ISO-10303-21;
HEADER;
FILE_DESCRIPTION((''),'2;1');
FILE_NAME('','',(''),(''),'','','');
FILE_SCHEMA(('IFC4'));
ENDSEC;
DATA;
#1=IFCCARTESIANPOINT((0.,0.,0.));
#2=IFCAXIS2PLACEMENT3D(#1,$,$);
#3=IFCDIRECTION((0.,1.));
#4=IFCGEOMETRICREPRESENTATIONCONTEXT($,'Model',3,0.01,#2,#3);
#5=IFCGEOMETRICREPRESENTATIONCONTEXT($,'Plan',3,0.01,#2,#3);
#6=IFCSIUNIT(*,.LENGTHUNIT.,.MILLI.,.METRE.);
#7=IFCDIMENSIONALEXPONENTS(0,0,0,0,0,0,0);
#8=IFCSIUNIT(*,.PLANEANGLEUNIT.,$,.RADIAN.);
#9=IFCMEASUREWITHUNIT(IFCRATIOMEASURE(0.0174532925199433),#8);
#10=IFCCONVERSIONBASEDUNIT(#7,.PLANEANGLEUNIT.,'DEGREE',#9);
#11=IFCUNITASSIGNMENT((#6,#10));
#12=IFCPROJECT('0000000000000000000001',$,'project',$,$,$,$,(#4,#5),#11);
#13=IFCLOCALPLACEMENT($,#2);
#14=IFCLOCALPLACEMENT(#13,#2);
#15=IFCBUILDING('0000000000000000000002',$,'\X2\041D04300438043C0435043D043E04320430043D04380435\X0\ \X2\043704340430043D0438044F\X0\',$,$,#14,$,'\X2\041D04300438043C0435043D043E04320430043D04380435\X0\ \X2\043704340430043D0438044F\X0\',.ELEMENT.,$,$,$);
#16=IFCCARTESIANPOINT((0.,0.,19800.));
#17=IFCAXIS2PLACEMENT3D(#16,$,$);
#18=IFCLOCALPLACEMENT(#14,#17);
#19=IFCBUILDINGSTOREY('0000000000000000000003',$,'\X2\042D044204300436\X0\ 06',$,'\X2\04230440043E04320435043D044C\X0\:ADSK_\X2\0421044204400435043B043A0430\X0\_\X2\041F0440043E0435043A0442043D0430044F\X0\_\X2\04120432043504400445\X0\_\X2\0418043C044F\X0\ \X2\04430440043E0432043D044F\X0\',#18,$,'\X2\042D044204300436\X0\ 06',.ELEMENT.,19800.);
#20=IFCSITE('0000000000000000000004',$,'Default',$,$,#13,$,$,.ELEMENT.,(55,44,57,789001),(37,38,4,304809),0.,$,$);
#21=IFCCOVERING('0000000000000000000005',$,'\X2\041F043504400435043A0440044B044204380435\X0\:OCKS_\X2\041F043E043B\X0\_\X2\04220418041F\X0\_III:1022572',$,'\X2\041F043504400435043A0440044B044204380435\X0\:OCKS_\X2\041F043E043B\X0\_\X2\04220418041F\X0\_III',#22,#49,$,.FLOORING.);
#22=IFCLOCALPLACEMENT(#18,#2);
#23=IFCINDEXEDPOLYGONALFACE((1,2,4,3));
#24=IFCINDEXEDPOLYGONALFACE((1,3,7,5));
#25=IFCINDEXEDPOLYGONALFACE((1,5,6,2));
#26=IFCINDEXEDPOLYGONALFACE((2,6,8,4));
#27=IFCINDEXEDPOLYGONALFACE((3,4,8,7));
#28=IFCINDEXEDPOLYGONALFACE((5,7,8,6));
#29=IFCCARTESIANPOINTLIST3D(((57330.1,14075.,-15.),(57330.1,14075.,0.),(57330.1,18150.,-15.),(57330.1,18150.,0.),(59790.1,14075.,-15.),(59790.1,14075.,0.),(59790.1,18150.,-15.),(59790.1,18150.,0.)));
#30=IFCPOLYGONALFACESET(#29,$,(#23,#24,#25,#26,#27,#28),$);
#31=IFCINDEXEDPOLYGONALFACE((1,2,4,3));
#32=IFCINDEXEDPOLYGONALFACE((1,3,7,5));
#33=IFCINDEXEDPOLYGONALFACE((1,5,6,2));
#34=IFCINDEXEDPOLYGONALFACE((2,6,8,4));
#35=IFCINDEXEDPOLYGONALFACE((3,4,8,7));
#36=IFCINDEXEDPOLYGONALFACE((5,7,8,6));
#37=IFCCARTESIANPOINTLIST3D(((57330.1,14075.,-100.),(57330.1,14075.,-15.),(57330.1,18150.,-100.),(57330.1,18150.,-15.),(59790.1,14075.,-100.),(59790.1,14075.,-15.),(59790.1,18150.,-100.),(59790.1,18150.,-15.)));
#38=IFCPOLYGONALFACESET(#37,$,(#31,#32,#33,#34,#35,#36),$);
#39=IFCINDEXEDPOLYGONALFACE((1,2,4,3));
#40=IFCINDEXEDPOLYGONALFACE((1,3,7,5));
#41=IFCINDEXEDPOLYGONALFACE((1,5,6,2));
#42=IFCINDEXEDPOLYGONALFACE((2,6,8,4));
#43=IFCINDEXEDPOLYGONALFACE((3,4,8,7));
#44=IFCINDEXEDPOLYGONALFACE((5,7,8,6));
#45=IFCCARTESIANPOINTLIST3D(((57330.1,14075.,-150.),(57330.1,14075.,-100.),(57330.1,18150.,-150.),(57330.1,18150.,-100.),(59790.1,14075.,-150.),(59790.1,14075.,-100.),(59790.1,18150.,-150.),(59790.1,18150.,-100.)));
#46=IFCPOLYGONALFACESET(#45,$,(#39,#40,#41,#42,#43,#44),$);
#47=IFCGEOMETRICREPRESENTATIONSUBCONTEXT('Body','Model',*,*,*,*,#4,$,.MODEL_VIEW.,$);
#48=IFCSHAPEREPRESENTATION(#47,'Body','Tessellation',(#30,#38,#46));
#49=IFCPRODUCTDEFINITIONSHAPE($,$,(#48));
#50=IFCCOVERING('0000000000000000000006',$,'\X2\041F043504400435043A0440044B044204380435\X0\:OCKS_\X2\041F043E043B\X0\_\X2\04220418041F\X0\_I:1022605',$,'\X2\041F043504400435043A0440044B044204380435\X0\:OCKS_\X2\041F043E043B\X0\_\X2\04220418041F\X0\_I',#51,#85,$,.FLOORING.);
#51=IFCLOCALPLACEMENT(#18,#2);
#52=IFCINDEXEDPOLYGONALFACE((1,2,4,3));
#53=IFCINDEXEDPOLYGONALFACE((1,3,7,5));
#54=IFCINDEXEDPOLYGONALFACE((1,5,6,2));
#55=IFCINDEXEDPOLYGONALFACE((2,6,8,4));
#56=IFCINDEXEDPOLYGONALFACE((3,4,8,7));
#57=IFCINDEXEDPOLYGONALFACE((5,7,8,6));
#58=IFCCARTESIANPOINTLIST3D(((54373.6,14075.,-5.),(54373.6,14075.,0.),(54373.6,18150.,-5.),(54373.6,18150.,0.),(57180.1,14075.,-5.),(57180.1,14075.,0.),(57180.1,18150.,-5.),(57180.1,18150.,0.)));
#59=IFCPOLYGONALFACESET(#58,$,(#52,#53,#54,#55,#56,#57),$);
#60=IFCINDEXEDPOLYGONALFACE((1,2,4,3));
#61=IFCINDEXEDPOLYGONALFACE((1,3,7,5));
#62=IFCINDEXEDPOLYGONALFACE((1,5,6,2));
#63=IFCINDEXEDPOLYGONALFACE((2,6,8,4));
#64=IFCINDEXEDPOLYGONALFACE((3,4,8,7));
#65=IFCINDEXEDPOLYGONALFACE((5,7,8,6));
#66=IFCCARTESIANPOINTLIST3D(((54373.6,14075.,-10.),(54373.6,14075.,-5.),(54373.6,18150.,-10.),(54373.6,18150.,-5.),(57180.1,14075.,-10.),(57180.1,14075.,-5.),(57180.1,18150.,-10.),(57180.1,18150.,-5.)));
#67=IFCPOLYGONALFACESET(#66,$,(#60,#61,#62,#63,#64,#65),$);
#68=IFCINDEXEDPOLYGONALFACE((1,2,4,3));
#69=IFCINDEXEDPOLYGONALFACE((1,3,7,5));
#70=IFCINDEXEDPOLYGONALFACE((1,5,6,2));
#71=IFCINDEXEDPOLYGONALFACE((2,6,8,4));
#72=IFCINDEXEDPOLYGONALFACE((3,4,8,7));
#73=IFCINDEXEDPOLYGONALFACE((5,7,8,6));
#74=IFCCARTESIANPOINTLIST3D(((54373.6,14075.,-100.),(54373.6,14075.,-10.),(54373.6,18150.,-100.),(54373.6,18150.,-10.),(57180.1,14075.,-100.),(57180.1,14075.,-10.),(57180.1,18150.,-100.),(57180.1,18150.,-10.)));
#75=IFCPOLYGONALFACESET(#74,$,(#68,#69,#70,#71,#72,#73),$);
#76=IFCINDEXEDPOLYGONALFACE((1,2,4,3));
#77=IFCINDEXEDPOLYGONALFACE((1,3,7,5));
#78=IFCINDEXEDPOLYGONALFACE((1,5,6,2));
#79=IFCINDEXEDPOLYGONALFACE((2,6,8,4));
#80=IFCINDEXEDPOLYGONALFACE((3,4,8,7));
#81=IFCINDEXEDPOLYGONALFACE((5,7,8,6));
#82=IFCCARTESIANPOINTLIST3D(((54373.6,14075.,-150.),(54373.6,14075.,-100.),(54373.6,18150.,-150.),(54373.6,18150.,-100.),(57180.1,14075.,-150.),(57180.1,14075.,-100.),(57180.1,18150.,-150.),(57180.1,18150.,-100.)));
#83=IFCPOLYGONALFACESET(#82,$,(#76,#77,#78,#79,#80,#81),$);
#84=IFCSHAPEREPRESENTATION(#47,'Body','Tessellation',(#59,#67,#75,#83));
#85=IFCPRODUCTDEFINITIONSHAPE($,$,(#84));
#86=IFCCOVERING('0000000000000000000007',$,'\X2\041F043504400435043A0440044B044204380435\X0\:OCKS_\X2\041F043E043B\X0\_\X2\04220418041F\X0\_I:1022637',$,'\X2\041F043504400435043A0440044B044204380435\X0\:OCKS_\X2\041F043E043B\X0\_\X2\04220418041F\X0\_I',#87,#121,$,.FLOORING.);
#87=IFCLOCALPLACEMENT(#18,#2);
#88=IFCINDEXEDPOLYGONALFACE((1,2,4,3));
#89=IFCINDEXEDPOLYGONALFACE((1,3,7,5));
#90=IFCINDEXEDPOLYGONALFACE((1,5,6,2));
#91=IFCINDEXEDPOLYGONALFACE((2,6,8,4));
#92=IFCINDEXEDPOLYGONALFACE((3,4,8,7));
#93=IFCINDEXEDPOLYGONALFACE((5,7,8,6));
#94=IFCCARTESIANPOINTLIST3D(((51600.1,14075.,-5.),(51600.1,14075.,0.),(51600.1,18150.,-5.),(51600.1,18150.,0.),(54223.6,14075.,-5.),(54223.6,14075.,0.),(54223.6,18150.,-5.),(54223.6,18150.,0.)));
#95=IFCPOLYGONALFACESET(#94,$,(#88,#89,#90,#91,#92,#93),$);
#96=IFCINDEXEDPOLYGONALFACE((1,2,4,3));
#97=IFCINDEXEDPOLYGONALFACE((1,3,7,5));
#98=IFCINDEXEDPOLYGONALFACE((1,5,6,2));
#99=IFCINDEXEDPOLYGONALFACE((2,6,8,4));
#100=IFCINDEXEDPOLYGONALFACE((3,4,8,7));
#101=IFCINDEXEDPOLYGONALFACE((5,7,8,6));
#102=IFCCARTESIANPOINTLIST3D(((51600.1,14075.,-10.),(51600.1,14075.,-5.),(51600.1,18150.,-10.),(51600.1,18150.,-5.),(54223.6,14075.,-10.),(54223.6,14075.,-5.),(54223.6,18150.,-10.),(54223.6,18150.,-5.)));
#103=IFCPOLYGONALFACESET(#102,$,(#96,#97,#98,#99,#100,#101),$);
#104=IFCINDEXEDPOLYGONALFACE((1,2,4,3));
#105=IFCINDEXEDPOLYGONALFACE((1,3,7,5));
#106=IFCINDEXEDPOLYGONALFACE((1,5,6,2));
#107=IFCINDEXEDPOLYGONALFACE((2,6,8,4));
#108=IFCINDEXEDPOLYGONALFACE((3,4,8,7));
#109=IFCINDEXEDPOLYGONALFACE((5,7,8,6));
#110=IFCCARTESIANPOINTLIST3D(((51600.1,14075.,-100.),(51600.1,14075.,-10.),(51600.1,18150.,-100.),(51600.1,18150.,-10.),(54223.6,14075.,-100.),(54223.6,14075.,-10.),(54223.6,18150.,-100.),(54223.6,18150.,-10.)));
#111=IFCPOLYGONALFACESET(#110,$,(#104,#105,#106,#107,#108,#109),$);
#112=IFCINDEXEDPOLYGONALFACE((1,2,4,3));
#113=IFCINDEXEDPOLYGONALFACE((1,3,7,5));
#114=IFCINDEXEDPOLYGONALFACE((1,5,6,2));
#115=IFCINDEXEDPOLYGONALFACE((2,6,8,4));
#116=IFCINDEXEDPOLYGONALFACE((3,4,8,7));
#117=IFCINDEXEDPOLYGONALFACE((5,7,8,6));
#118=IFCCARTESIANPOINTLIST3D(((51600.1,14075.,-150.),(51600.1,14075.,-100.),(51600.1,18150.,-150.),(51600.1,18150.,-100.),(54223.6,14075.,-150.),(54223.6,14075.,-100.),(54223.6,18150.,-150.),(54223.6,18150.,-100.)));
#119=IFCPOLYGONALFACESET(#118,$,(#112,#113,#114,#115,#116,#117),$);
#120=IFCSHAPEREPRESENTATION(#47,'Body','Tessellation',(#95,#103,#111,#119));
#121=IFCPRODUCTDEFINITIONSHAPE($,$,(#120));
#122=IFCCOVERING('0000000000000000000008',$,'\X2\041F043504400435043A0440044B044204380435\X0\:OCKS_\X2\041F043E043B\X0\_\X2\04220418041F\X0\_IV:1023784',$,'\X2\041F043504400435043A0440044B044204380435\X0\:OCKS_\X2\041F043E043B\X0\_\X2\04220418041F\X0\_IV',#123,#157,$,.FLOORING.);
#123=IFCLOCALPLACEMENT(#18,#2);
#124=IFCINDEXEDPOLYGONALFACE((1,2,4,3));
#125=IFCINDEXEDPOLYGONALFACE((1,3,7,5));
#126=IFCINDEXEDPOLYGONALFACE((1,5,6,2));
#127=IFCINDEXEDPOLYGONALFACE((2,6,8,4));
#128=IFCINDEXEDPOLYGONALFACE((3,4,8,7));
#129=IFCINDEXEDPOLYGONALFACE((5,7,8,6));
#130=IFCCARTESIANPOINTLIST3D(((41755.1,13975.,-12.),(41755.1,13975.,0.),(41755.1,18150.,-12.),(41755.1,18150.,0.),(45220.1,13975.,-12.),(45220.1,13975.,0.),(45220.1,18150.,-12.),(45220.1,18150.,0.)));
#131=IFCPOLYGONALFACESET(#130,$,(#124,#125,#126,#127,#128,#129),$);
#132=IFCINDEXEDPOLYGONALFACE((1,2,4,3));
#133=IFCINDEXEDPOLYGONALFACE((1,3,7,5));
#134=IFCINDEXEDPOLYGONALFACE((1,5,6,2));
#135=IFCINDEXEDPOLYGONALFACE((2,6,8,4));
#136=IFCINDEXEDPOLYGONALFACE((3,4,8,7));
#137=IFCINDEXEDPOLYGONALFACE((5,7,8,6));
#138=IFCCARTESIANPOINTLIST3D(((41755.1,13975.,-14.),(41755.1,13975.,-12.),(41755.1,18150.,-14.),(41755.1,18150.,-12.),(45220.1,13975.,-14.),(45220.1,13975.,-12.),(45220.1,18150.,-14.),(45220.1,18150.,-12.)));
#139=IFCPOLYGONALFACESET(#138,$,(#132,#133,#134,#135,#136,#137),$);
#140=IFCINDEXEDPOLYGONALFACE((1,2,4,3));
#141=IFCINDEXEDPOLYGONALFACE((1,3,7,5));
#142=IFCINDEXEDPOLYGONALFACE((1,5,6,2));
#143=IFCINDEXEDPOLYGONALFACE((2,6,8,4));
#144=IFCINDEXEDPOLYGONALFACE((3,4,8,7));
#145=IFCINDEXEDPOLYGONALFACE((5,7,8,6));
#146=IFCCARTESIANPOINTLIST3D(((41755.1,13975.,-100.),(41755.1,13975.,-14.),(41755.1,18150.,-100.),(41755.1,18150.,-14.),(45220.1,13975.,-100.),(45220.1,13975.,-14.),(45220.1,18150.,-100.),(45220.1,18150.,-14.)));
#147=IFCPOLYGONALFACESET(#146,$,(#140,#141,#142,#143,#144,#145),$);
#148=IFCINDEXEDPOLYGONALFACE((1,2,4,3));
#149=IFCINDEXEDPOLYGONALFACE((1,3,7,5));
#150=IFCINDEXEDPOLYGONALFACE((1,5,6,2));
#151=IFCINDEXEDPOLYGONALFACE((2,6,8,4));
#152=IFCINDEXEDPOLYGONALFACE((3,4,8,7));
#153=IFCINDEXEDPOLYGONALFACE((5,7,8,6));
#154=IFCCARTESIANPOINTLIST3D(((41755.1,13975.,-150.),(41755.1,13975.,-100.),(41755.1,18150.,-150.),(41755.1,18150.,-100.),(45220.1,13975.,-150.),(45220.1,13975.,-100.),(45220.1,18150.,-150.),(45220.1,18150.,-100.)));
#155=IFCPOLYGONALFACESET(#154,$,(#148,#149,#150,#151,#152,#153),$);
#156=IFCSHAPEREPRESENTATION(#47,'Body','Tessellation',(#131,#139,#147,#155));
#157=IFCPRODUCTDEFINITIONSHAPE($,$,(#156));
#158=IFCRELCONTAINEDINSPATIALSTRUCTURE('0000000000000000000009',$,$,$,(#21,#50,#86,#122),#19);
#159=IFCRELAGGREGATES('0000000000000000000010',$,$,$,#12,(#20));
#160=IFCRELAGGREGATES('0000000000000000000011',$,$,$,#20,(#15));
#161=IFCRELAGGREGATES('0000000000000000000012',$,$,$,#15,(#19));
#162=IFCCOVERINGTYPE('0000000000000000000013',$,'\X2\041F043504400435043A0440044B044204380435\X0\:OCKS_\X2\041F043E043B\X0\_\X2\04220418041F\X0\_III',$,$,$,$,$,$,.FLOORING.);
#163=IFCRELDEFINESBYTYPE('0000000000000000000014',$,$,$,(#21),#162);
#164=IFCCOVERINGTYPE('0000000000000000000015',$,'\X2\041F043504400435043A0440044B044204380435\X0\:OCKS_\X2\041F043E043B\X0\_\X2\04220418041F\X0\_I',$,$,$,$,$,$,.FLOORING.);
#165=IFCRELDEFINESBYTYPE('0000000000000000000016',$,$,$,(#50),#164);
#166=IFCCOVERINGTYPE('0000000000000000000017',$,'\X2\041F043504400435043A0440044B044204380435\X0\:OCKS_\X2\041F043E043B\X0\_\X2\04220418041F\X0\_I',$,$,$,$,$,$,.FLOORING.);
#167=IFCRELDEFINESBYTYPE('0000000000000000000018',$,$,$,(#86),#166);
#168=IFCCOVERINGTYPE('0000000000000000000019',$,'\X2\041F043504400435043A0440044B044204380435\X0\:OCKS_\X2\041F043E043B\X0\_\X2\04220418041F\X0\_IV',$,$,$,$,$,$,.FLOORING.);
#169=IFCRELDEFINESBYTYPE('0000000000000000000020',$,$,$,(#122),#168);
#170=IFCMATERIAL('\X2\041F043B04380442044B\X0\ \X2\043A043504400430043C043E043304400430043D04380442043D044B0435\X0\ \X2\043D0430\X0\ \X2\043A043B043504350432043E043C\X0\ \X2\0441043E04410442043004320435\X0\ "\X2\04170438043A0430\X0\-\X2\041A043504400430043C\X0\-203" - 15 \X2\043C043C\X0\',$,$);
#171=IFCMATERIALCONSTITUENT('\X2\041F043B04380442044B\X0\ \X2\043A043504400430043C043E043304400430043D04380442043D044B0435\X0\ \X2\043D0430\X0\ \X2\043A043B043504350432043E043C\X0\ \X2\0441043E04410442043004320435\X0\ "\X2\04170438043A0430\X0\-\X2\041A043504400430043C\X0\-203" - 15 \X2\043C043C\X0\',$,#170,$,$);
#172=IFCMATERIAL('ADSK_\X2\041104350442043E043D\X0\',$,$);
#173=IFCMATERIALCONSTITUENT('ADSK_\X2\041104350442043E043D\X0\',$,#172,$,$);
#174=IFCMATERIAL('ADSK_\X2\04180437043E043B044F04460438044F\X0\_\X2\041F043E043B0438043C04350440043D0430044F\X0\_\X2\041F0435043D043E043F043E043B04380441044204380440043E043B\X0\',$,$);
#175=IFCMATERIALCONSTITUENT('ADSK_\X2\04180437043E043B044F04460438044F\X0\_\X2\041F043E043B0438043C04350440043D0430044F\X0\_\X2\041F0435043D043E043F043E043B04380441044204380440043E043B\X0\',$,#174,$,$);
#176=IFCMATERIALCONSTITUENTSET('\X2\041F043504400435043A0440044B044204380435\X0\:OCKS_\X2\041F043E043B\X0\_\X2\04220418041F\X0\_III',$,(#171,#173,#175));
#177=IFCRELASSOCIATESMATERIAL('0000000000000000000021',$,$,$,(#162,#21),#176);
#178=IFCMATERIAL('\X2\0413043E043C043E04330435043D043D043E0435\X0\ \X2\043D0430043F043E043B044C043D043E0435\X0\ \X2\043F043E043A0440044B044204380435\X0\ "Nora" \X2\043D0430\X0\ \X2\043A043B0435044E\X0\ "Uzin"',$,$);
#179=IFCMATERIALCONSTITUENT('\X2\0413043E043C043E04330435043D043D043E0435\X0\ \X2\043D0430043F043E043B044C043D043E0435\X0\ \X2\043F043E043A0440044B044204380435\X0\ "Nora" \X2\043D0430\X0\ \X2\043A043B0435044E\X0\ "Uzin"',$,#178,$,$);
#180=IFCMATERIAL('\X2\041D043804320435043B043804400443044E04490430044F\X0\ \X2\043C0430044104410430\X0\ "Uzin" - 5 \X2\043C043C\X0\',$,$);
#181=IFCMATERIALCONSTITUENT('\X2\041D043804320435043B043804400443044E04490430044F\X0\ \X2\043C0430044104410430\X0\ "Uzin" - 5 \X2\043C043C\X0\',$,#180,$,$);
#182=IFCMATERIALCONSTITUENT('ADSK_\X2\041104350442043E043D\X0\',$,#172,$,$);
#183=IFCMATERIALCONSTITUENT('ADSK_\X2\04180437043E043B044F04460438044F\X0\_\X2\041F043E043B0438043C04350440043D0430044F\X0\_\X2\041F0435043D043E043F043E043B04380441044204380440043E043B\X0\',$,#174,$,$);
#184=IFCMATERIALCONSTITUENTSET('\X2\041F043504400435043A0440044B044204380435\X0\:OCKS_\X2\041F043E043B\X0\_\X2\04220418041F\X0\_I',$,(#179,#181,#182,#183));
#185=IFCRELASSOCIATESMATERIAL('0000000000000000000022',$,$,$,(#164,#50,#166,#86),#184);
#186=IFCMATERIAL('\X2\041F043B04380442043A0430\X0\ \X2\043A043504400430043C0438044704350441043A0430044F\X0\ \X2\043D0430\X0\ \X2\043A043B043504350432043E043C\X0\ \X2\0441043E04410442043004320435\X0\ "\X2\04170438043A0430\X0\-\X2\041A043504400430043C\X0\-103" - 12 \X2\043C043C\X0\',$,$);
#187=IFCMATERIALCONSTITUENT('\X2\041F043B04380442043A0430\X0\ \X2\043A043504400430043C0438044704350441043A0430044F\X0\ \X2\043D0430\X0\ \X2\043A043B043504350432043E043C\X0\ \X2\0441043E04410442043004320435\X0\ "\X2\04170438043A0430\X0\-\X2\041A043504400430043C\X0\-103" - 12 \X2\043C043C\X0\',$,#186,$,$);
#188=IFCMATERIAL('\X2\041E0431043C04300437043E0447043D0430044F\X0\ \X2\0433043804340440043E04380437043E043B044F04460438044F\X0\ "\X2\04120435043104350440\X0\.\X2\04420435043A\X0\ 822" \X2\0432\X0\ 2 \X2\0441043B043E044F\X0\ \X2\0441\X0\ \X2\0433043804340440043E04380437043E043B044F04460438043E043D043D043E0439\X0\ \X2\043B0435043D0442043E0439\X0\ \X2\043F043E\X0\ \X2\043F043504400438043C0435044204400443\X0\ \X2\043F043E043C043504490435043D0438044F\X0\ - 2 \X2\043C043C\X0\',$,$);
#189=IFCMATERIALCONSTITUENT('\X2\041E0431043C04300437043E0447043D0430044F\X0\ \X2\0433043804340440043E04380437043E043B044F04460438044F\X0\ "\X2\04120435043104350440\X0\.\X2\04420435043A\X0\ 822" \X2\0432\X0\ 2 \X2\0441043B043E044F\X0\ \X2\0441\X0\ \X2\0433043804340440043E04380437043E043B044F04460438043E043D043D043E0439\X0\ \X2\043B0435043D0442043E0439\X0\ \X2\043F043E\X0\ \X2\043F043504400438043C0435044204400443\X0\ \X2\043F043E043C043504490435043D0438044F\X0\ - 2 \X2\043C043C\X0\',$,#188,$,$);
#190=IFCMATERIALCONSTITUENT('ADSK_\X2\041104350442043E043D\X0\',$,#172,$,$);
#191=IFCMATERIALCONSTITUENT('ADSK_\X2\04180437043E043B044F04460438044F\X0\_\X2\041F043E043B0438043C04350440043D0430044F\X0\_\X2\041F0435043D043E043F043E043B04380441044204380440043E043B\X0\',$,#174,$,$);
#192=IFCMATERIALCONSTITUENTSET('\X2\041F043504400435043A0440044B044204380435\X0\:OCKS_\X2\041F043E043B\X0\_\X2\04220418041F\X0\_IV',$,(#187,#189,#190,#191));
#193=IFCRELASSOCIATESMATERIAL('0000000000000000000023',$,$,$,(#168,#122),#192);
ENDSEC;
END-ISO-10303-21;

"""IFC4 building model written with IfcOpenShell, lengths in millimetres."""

from ifc_helpers import new_model, entity, si_unit, converted_unit, direction, frame, origin, place, context, subcontext, project, spatial, indexed_curve, outline, extrude, material, constituent, constituent_set, type_object, element, save


model = new_model("IFC4")

# Units and contexts
model_context = context("Model", 3, precision=0.01, world=origin(), true_north=direction((0.0, 1.0)))
plan_context = context("Plan", 3, precision=0.01, world=origin(), true_north=direction((0.0, 1.0)))
body_context = subcontext(model_context, "Body", "Model", "MODEL_VIEW")
ifc_project = project(units=[si_unit("LENGTHUNIT", "METRE", prefix="MILLI"), converted_unit("PLANEANGLEUNIT", "DEGREE", entity("IfcRatioMeasure", 0.0174532925199433), si_unit("PLANEANGLEUNIT", "RADIAN"), dimensions=[0, 0, 0, 0, 0, 0, 0])], contexts=[model_context, plan_context])

# Site, building, storey
site_placement = place(None, frame((0.0, 0.0, 0.0)))
site = spatial("IfcSite", under=ifc_project, at=site_placement, Name="Default", CompositionType="ELEMENT", RefLatitude=(55, 44, 57, 789001), RefLongitude=(37, 38, 4, 304809), RefElevation=0.0)
building_placement = place(site_placement, origin())
building = spatial("IfcBuilding", under=site, at=building_placement, Name="Наименование здания", LongName="Наименование здания", CompositionType="ELEMENT")
storey_placement = place(building_placement, frame((0.0, 0.0, 19800.0)))
storey = spatial("IfcBuildingStorey", under=building, at=storey_placement, Name="Этаж 06", ObjectType="Уровень:ADSK_Стрелка_Проектная_Вверх_Имя уровня", LongName="Этаж 06", CompositionType="ELEMENT", Elevation=19800.0)

# Coverings
ifc_material_1 = material(Name="Плиты керамогранитные на клеевом составе \"Зика-Керам-203\" - 15 мм")
ifc_material_2 = material(Name="Обмазочная гидроизоляция \"Вебер.тек 822\" в 2 слоя с гидроизоляционной лентой по периметру помещения - 2 мм")
ifc_material_3 = material(Name="ADSK_Бетон")
ifc_material_4 = material(Name="ADSK_Изоляция_Полимерная_Пенополистирол")
ifc_constituent_1 = constituent(ifc_material_1, Name="Плиты керамогранитные на клеевом составе \"Зика-Керам-203\" - 15 мм")
ifc_constituent_2 = constituent(ifc_material_3, Name="ADSK_Бетон")
ifc_constituent_3 = constituent(ifc_material_4, Name="ADSK_Изоляция_Полимерная_Пенополистирол")
ifc_constituent_set_1 = constituent_set(constituents=[ifc_constituent_1, ifc_constituent_2, ifc_constituent_3], Name="Перекрытие:OCKS_Пол_ТИП_III")
covering_type_1 = type_object("IfcCoveringType", Name="Перекрытие:OCKS_Пол_ТИП_III", PredefinedType="FLOORING", material=ifc_constituent_set_1)
covering_1_placement = place(storey_placement, origin())
element("IfcCovering", 1, at=covering_1_placement, inside=storey, type_object=covering_type_1, material=ifc_constituent_set_1, Name="Перекрытие:OCKS_Пол_ТИП_III:1022572", ObjectType="Перекрытие:OCKS_Пол_ТИП_III", PredefinedType="FLOORING", context=body_context, shape_type="SweptSolid", body=[
    extrude(outline(indexed_curve([(-1230.0, -2037.5), (1230.0, -2037.5), (1230.0, 2037.5), (-1230.0, 2037.5), (-1230.0, -2037.5)], self_intersect=False)), frame((58560.1, 16112.5, -15.0), z_axis=(0.0, 0.0, 1.0), x_axis=(-1.0, 0.0, 0.0)), (0.0, 0.0, 1.0), 15.0),
    extrude(outline(indexed_curve([(-1230.0, -2037.5), (1230.0, -2037.5), (1230.0, 2037.5), (-1230.0, 2037.5), (-1230.0, -2037.5)], self_intersect=False)), frame((58560.1, 16112.5, -100.0), z_axis=(0.0, 0.0, 1.0), x_axis=(-1.0, 0.0, 0.0)), (0.0, 0.0, 1.0), 85.0),
    extrude(outline(indexed_curve([(-1230.0, -2037.5), (1230.0, -2037.5), (1230.0, 2037.5), (-1230.0, 2037.5), (-1230.0, -2037.5)], self_intersect=False)), frame((58560.1, 16112.5, -150.0), z_axis=(0.0, 0.0, 1.0), x_axis=(-1.0, 0.0, 0.0)), (0.0, 0.0, 1.0), 50.0),
])
ifc_material_5 = material(Name="Гомогенное напольное покрытие \"Nora\" на клею \"Uzin\"")
ifc_constituent_4 = constituent(ifc_material_5, Name="Гомогенное напольное покрытие \"Nora\" на клею \"Uzin\"")
ifc_material_6 = material(Name="Нивелирующая масса \"Uzin\" - 5 мм")
ifc_constituent_5 = constituent(ifc_material_6, Name="Нивелирующая масса \"Uzin\" - 5 мм")
ifc_constituent_6 = constituent(ifc_material_3, Name="ADSK_Бетон")
ifc_constituent_7 = constituent(ifc_material_4, Name="ADSK_Изоляция_Полимерная_Пенополистирол")
ifc_constituent_set_2 = constituent_set(constituents=[ifc_constituent_4, ifc_constituent_5, ifc_constituent_6, ifc_constituent_7], Name="Перекрытие:OCKS_Пол_ТИП_I")
covering_type_2 = type_object("IfcCoveringType", Name="Перекрытие:OCKS_Пол_ТИП_I", PredefinedType="FLOORING", material=ifc_constituent_set_2)
covering_2_placement = place(storey_placement, origin())
element("IfcCovering", 2, at=covering_2_placement, inside=storey, type_object=covering_type_2, material=ifc_constituent_set_2, Name="Перекрытие:OCKS_Пол_ТИП_I:1022605", ObjectType="Перекрытие:OCKS_Пол_ТИП_I", PredefinedType="FLOORING", context=body_context, shape_type="SweptSolid", body=[
    extrude(outline(indexed_curve([(-1403.3, -2037.5), (1403.3, -2037.5), (1403.3, 2037.5), (-1403.3, 2037.5), (-1403.3, -2037.5)], self_intersect=False)), frame((55776.9, 16112.5, -5.0), z_axis=(0.0, 0.0, 1.0), x_axis=(-1.0, 0.0, 0.0)), (0.0, 0.0, 1.0), 5.0),
    extrude(outline(indexed_curve([(-1403.3, -2037.5), (1403.3, -2037.5), (1403.3, 2037.5), (-1403.3, 2037.5), (-1403.3, -2037.5)], self_intersect=False)), frame((55776.9, 16112.5, -10.0), z_axis=(0.0, 0.0, 1.0), x_axis=(-1.0, 0.0, 0.0)), (0.0, 0.0, 1.0), 5.0),
    extrude(outline(indexed_curve([(-1403.3, -2037.5), (1403.3, -2037.5), (1403.3, 2037.5), (-1403.3, 2037.5), (-1403.3, -2037.5)], self_intersect=False)), frame((55776.9, 16112.5, -100.0), z_axis=(0.0, 0.0, 1.0), x_axis=(-1.0, 0.0, 0.0)), (0.0, 0.0, 1.0), 90.0),
    extrude(outline(indexed_curve([(-1403.3, -2037.5), (1403.3, -2037.5), (1403.3, 2037.5), (-1403.3, 2037.5), (-1403.3, -2037.5)], self_intersect=False)), frame((55776.9, 16112.5, -150.0), z_axis=(0.0, 0.0, 1.0), x_axis=(-1.0, 0.0, 0.0)), (0.0, 0.0, 1.0), 50.0),
])
covering_type_3 = type_object("IfcCoveringType", Name="Перекрытие:OCKS_Пол_ТИП_I", PredefinedType="FLOORING", material=ifc_constituent_set_2)
covering_3_placement = place(storey_placement, origin())
element("IfcCovering", 3, at=covering_3_placement, inside=storey, type_object=covering_type_3, material=ifc_constituent_set_2, Name="Перекрытие:OCKS_Пол_ТИП_I:1022637", ObjectType="Перекрытие:OCKS_Пол_ТИП_I", PredefinedType="FLOORING", context=body_context, shape_type="SweptSolid", body=[
    extrude(outline(indexed_curve([(-1311.7, -2037.5), (1311.7, -2037.5), (1311.7, 2037.5), (-1311.7, 2037.5), (-1311.7, -2037.5)], self_intersect=False)), frame((52911.9, 16112.5, -5.0), z_axis=(0.0, 0.0, 1.0), x_axis=(-1.0, 0.0, 0.0)), (0.0, 0.0, 1.0), 5.0),
    extrude(outline(indexed_curve([(-1311.7, -2037.5), (1311.7, -2037.5), (1311.7, 2037.5), (-1311.7, 2037.5), (-1311.7, -2037.5)], self_intersect=False)), frame((52911.9, 16112.5, -10.0), z_axis=(0.0, 0.0, 1.0), x_axis=(-1.0, 0.0, 0.0)), (0.0, 0.0, 1.0), 5.0),
    extrude(outline(indexed_curve([(-1311.7, -2037.5), (1311.7, -2037.5), (1311.7, 2037.5), (-1311.7, 2037.5), (-1311.7, -2037.5)], self_intersect=False)), frame((52911.9, 16112.5, -100.0), z_axis=(0.0, 0.0, 1.0), x_axis=(-1.0, 0.0, 0.0)), (0.0, 0.0, 1.0), 90.0),
    extrude(outline(indexed_curve([(-1311.7, -2037.5), (1311.7, -2037.5), (1311.7, 2037.5), (-1311.7, 2037.5), (-1311.7, -2037.5)], self_intersect=False)), frame((52911.9, 16112.5, -150.0), z_axis=(0.0, 0.0, 1.0), x_axis=(-1.0, 0.0, 0.0)), (0.0, 0.0, 1.0), 50.0),
])
ifc_material_7 = material(Name="Плитка керамическая на клеевом составе \"Зика-Керам-103\" - 12 мм")
ifc_constituent_8 = constituent(ifc_material_7, Name="Плитка керамическая на клеевом составе \"Зика-Керам-103\" - 12 мм")
ifc_constituent_9 = constituent(ifc_material_2, Name="Обмазочная гидроизоляция \"Вебер.тек 822\" в 2 слоя с гидроизоляционной лентой по периметру помещения - 2 мм")
ifc_constituent_10 = constituent(ifc_material_3, Name="ADSK_Бетон")
ifc_constituent_11 = constituent(ifc_material_4, Name="ADSK_Изоляция_Полимерная_Пенополистирол")
ifc_constituent_set_3 = constituent_set(constituents=[ifc_constituent_8, ifc_constituent_9, ifc_constituent_10, ifc_constituent_11], Name="Перекрытие:OCKS_Пол_ТИП_IV")
covering_type_4 = type_object("IfcCoveringType", Name="Перекрытие:OCKS_Пол_ТИП_IV", PredefinedType="FLOORING", material=ifc_constituent_set_3)
covering_4_placement = place(storey_placement, origin())
element("IfcCovering", 4, at=covering_4_placement, inside=storey, type_object=covering_type_4, material=ifc_constituent_set_3, Name="Перекрытие:OCKS_Пол_ТИП_IV:1023784", ObjectType="Перекрытие:OCKS_Пол_ТИП_IV", PredefinedType="FLOORING", context=body_context, shape_type="SweptSolid", body=[
    extrude(outline(indexed_curve([(-1732.5, -2087.5), (1732.5, -2087.5), (1732.5, 2087.5), (-1732.5, 2087.5), (-1732.5, -2087.5)], self_intersect=False)), frame((43487.6, 16062.5, -12.0), z_axis=(0.0, 0.0, 1.0), x_axis=(-1.0, 0.0, 0.0)), (0.0, 0.0, 1.0), 12.0),
    extrude(outline(indexed_curve([(-1732.5, -2087.5), (1732.5, -2087.5), (1732.5, 2087.5), (-1732.5, 2087.5), (-1732.5, -2087.5)], self_intersect=False)), frame((43487.6, 16062.5, -14.0), z_axis=(0.0, 0.0, 1.0), x_axis=(-1.0, 0.0, 0.0)), (0.0, 0.0, 1.0), 2.0),
    extrude(outline(indexed_curve([(-1732.5, -2087.5), (1732.5, -2087.5), (1732.5, 2087.5), (-1732.5, 2087.5), (-1732.5, -2087.5)], self_intersect=False)), frame((43487.6, 16062.5, -100.0), z_axis=(0.0, 0.0, 1.0), x_axis=(-1.0, 0.0, 0.0)), (0.0, 0.0, 1.0), 86.0),
    extrude(outline(indexed_curve([(-1732.5, -2087.5), (1732.5, -2087.5), (1732.5, 2087.5), (-1732.5, 2087.5), (-1732.5, -2087.5)], self_intersect=False)), frame((43487.6, 16062.5, -150.0), z_axis=(0.0, 0.0, 1.0), x_axis=(-1.0, 0.0, 0.0)), (0.0, 0.0, 1.0), 50.0),
])

save(model, "model.ifc")
